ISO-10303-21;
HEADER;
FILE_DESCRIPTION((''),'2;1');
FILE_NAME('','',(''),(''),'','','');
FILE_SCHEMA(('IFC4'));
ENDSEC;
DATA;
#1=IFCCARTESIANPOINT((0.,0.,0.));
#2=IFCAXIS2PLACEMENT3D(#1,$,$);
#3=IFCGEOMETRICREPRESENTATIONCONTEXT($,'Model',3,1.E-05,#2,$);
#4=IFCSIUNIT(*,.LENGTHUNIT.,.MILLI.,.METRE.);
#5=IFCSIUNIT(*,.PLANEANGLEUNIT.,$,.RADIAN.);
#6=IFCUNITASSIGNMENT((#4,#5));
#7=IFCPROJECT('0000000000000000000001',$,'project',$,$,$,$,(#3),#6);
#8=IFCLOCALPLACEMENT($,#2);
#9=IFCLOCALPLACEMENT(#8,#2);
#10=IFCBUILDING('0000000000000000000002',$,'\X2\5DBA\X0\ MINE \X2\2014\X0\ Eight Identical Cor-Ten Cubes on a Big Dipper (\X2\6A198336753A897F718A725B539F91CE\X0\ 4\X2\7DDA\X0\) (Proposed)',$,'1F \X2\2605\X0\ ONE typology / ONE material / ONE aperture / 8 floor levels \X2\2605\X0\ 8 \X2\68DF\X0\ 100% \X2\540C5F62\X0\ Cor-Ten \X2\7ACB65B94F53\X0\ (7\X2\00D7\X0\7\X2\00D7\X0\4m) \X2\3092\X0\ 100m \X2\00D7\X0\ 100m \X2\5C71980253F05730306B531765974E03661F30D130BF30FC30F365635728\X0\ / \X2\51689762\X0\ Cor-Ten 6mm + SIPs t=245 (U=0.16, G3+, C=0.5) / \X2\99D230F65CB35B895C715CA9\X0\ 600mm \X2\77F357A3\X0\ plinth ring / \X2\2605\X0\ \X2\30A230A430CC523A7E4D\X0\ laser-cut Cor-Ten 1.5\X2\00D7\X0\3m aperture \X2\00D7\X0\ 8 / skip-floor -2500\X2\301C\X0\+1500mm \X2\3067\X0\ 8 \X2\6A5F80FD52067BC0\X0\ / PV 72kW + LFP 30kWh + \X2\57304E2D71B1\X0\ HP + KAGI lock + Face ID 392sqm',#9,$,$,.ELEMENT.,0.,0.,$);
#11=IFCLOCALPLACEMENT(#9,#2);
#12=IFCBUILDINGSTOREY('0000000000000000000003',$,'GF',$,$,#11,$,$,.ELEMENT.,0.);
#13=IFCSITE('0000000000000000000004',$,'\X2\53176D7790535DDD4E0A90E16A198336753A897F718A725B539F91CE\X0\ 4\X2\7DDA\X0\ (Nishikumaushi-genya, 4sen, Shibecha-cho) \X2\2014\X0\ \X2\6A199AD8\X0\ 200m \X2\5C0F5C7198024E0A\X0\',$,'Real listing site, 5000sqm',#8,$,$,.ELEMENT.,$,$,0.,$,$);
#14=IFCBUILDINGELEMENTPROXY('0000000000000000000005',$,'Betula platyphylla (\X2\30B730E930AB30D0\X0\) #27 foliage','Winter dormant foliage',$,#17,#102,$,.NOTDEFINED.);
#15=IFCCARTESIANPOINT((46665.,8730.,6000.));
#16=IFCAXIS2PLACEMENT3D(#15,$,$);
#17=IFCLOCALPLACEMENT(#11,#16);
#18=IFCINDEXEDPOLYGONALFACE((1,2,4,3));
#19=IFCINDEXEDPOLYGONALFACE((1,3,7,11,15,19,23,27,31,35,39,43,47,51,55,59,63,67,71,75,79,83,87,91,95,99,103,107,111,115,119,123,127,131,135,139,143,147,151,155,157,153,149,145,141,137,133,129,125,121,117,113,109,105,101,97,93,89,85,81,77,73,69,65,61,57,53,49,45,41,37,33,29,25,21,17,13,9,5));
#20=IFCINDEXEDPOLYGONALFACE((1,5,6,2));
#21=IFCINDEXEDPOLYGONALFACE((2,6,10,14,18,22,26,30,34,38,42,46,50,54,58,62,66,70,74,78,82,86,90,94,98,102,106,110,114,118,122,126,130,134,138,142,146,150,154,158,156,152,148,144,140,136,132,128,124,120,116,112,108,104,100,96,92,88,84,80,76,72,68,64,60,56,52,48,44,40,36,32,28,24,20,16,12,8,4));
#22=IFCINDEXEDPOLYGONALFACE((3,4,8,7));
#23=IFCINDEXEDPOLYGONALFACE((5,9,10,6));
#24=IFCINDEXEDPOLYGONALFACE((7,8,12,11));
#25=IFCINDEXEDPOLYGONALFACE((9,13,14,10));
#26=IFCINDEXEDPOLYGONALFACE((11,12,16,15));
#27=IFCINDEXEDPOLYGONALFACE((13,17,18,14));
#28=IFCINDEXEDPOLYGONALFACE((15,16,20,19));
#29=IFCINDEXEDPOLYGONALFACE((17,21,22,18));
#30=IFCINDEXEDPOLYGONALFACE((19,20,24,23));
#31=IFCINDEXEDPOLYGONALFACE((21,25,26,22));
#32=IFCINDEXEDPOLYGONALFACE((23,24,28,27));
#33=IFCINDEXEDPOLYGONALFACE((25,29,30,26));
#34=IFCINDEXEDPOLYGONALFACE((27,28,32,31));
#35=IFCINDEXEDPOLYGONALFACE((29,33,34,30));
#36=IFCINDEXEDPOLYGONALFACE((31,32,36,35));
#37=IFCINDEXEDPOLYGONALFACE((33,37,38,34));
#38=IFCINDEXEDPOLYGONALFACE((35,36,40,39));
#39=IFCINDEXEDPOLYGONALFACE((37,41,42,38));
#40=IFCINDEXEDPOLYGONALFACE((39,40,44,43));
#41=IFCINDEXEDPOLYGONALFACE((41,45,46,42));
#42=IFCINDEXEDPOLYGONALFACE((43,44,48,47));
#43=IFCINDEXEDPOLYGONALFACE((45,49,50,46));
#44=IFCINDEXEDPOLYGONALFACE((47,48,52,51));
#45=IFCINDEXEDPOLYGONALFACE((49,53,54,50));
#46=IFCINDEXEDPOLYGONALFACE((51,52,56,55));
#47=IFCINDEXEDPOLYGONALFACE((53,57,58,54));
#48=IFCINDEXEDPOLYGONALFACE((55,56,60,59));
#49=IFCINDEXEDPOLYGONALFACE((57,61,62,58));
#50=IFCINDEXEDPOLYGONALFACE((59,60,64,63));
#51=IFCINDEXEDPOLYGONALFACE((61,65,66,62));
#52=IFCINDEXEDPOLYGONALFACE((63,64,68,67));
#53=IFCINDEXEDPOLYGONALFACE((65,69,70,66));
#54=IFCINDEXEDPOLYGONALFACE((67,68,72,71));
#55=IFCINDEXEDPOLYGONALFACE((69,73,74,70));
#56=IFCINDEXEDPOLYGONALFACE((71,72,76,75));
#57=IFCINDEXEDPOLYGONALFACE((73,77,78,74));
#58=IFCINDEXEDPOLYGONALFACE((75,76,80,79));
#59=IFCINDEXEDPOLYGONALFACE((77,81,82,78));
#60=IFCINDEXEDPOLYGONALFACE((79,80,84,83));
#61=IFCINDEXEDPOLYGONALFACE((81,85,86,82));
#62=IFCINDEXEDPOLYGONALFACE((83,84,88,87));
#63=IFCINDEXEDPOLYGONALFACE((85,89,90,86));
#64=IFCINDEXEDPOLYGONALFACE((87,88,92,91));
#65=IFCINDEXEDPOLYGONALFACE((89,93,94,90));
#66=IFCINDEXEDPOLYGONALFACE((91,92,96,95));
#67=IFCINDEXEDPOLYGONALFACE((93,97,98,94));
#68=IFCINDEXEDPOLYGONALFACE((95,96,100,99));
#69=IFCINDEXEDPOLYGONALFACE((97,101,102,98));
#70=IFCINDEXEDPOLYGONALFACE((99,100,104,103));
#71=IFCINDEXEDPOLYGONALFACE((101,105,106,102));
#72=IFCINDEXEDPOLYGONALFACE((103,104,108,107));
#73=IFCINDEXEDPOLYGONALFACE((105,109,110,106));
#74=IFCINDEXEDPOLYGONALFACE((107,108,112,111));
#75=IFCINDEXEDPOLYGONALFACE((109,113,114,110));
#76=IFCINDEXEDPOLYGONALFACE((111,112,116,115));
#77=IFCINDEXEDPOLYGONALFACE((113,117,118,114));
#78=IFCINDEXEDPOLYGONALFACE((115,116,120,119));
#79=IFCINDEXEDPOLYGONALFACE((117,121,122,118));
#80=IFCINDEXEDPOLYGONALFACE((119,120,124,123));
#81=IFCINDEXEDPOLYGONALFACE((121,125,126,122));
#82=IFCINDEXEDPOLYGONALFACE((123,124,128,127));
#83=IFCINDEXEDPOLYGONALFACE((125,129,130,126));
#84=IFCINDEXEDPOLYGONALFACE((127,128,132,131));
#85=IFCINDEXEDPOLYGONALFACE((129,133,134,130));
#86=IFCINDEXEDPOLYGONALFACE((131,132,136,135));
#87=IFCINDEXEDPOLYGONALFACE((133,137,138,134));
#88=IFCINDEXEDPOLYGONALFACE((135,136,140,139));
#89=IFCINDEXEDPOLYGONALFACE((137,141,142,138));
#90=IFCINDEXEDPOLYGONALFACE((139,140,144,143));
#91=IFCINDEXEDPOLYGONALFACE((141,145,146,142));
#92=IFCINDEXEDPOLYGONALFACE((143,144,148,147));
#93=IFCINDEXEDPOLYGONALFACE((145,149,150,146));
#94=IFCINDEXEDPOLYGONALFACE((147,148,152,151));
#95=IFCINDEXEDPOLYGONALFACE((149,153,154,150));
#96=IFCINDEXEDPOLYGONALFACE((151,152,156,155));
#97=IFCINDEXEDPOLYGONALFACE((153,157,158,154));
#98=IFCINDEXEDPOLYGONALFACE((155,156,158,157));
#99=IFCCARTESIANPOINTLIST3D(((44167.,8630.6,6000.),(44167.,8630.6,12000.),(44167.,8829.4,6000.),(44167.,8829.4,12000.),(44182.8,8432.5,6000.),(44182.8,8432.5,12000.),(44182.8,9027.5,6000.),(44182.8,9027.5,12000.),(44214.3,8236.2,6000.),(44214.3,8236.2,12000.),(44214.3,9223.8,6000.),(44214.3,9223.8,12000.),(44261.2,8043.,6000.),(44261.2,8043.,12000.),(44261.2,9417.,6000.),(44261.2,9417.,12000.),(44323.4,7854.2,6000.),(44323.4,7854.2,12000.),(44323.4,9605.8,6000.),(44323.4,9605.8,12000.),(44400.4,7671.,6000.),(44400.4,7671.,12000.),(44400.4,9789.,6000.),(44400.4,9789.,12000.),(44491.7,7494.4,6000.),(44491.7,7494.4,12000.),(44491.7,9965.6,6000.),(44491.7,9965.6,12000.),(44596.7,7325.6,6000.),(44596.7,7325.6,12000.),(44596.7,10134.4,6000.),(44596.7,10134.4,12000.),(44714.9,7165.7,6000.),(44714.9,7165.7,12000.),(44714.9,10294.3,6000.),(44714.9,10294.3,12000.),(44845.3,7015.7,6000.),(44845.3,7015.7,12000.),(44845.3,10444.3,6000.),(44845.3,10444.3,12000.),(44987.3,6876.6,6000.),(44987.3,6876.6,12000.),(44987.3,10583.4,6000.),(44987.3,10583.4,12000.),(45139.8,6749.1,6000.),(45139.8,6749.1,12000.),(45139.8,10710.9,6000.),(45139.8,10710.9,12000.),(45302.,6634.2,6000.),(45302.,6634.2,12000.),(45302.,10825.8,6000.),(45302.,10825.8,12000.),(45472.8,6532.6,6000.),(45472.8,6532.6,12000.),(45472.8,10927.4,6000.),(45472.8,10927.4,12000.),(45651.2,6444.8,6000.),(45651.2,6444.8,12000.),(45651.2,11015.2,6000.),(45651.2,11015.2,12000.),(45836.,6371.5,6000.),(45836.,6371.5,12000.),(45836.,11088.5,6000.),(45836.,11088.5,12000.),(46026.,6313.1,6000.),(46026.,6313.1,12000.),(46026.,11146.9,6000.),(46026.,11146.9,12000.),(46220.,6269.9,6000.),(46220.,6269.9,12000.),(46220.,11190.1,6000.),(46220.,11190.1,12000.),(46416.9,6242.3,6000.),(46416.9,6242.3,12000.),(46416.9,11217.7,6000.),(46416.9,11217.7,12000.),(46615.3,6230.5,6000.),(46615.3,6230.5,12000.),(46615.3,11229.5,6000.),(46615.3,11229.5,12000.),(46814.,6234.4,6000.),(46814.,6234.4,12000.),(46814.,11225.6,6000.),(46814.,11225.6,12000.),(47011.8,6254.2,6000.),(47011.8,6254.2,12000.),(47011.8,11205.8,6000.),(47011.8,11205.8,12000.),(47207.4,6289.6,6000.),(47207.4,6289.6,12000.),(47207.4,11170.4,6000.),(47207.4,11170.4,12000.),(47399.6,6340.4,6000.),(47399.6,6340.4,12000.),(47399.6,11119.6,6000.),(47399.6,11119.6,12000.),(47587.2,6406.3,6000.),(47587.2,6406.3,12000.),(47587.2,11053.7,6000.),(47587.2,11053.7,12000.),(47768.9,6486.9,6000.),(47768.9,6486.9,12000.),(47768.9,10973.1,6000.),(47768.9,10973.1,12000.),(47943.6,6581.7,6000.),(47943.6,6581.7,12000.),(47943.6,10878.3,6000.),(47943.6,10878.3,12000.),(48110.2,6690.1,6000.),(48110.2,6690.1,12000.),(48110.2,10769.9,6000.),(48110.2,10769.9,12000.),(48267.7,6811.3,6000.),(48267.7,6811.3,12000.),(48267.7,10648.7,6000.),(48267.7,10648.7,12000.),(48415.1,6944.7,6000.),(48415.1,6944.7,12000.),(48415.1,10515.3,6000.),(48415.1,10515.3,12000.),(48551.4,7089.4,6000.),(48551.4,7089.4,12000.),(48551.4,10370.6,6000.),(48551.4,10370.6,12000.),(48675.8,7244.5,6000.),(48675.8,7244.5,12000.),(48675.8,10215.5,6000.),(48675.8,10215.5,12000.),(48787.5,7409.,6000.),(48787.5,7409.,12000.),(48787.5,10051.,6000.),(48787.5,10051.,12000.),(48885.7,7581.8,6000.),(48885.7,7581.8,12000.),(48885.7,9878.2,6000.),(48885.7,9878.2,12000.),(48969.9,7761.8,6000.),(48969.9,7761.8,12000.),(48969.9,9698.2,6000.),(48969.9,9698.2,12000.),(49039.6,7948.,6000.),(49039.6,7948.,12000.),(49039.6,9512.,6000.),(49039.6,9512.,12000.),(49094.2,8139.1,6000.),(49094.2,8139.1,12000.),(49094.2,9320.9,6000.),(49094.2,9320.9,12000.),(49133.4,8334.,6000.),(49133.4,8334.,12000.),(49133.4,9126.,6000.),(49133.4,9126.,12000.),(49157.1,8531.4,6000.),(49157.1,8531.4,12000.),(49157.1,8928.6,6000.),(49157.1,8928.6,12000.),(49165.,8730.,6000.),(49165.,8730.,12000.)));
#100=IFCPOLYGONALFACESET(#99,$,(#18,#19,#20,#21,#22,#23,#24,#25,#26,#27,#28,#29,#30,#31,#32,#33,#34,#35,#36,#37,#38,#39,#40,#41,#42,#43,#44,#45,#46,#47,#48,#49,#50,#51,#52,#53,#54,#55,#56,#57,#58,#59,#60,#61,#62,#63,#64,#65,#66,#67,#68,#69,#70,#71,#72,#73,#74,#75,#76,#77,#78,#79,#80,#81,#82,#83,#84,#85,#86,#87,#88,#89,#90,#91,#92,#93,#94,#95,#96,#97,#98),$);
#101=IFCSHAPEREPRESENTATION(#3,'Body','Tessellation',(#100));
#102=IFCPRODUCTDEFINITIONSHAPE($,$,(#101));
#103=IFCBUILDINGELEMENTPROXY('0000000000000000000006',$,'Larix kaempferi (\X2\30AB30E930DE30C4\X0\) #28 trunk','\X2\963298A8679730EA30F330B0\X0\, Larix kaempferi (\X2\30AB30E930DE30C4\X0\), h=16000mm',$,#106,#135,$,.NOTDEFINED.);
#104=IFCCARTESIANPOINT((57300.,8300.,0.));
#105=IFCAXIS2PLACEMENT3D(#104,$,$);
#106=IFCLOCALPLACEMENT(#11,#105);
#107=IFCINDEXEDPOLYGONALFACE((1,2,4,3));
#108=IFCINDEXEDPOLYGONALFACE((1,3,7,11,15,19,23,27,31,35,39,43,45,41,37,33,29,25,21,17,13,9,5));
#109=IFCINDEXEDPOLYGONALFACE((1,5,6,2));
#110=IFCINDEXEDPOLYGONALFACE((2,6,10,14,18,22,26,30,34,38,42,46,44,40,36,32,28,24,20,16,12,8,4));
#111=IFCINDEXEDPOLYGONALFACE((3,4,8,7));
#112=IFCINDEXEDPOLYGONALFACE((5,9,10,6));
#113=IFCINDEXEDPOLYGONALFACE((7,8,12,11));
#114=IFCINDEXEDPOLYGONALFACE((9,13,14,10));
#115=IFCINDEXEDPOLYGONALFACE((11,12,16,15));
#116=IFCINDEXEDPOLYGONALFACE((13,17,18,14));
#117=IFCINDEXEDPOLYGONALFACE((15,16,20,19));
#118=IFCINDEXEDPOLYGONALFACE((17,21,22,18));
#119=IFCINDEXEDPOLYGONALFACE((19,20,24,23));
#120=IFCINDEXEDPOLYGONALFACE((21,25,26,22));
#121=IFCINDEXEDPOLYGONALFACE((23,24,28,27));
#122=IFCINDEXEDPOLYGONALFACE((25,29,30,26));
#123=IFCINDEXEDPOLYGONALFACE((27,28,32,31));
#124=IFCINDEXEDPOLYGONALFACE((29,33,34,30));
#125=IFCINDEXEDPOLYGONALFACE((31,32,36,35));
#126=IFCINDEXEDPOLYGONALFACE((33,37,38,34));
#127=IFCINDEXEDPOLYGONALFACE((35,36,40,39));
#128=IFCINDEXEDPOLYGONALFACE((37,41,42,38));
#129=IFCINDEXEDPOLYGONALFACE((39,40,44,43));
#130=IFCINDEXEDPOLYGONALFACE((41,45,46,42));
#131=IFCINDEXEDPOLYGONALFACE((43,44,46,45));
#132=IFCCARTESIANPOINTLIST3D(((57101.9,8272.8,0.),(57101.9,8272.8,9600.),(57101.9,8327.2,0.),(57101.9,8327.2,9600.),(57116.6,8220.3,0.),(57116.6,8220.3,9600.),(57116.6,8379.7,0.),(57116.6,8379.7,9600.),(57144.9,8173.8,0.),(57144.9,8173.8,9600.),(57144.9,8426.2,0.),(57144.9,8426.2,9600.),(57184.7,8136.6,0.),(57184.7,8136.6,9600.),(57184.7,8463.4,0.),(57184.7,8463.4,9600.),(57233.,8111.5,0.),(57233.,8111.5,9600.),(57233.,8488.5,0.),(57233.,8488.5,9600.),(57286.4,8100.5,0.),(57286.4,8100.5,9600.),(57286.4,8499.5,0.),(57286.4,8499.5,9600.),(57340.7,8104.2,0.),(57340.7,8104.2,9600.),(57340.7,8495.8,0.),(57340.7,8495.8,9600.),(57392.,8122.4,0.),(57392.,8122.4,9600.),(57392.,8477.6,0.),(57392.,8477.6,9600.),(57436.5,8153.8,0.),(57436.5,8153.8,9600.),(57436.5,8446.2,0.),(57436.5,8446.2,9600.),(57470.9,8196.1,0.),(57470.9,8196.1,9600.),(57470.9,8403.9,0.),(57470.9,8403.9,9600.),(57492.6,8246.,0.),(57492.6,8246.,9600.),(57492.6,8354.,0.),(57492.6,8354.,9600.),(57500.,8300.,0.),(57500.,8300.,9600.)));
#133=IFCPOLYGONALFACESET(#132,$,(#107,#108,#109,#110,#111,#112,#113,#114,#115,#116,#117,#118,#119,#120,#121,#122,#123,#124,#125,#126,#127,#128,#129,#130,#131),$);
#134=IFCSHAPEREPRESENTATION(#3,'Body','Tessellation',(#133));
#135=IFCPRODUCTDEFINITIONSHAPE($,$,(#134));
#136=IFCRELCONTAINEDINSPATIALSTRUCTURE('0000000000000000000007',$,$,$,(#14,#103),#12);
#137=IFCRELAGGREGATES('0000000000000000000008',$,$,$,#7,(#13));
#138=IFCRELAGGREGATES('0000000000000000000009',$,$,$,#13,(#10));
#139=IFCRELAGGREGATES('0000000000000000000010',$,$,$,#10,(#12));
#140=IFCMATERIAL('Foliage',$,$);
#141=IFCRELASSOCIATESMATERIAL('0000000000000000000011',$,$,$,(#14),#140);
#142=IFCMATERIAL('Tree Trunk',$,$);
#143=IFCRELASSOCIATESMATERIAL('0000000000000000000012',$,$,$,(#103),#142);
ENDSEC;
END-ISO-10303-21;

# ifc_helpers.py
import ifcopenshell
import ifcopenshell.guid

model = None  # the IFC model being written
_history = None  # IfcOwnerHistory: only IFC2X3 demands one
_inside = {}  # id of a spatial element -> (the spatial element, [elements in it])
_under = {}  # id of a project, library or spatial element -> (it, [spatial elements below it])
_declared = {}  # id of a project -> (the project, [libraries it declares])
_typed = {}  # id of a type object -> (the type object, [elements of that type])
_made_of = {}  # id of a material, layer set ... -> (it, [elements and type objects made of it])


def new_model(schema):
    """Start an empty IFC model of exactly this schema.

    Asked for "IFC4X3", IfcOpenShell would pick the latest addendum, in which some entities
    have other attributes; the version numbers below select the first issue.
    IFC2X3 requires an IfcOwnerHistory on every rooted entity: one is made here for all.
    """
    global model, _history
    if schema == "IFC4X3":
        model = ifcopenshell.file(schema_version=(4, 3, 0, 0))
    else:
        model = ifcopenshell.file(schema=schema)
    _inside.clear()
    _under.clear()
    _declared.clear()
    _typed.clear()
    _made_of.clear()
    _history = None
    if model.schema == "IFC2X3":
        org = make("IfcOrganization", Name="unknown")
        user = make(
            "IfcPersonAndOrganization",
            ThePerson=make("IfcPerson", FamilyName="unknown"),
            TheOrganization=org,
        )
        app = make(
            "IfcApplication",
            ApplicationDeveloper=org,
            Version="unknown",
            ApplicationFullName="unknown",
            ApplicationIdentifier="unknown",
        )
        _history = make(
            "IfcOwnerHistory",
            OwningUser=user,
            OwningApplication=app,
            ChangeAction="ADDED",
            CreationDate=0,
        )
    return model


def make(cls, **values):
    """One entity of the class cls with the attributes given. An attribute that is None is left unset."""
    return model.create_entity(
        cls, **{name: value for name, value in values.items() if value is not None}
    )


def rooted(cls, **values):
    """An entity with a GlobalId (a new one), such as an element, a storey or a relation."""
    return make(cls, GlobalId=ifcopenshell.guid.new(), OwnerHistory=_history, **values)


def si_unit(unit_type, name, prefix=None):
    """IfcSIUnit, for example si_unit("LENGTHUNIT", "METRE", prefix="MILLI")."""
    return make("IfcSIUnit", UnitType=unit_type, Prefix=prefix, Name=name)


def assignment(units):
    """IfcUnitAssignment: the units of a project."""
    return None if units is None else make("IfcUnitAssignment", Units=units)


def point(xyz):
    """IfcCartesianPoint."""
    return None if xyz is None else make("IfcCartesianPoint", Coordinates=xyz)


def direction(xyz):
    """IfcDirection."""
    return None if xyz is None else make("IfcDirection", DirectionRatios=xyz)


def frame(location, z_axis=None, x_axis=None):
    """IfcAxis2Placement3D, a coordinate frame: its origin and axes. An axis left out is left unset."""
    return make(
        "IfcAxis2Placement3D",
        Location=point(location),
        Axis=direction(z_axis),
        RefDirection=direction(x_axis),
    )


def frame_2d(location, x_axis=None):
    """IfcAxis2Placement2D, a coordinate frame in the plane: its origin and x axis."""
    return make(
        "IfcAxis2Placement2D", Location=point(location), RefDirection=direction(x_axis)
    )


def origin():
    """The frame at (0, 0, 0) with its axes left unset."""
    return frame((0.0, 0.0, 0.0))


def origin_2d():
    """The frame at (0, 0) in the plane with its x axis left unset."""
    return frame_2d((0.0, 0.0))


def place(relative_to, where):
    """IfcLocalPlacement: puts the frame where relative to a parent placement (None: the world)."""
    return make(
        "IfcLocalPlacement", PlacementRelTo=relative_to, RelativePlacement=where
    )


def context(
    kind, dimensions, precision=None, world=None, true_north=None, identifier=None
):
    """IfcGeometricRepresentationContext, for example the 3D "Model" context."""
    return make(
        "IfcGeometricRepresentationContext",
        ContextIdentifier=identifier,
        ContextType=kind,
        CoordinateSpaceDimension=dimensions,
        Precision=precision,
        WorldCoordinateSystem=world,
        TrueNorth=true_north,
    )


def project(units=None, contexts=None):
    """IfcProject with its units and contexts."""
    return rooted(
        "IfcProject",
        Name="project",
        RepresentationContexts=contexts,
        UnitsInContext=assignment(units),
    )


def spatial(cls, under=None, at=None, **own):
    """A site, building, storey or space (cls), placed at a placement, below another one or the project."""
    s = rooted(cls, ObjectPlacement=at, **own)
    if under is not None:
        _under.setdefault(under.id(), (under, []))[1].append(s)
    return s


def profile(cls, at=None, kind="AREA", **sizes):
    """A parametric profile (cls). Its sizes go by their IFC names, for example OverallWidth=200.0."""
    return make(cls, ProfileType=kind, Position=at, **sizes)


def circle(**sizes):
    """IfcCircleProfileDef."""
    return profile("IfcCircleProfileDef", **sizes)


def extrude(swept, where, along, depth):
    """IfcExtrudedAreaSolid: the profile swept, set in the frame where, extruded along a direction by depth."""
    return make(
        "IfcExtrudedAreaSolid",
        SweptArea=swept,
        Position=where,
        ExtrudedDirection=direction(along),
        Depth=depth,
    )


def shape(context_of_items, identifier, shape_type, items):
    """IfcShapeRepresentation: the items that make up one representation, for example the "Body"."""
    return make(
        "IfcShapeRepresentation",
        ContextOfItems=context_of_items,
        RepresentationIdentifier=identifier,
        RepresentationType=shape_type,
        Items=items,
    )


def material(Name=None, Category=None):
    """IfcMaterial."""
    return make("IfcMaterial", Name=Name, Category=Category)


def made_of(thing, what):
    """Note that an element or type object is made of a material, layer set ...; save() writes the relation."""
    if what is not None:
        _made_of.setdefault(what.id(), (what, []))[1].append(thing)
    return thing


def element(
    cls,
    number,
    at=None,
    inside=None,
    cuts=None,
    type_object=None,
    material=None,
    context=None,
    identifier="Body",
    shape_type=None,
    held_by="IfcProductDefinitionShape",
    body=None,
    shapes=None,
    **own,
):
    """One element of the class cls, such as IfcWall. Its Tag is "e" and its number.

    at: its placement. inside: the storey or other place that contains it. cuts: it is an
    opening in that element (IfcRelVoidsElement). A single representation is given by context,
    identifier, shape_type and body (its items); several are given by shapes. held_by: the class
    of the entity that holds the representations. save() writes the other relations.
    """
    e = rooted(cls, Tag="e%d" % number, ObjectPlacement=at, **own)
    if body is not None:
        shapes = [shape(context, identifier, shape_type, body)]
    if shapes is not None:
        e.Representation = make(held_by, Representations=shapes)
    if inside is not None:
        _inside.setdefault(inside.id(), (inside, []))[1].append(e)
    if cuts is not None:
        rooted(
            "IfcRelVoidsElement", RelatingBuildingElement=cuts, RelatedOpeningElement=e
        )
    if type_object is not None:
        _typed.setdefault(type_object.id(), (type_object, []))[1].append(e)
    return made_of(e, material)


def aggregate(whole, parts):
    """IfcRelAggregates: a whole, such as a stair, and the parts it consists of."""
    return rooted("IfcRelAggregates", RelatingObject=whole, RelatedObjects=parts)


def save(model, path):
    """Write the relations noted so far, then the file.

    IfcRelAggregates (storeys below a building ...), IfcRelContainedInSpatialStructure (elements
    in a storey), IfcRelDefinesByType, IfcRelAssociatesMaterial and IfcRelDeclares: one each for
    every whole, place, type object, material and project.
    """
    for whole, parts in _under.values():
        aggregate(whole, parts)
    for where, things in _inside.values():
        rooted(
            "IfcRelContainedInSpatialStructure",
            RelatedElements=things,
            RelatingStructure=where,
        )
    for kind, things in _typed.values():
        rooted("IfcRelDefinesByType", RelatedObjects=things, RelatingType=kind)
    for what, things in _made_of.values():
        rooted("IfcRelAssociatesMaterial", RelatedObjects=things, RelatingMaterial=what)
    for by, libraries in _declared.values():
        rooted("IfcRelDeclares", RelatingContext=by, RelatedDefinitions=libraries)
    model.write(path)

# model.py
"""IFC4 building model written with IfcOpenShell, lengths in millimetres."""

from ifc_helpers import new_model, si_unit, frame, origin, origin_2d, place, context, project, spatial, circle, extrude, material, element, save


model = new_model("IFC4")

# Units and contexts
model_context = context("Model", 3, precision=1e-05, world=origin())
ifc_project = project(units=[si_unit("LENGTHUNIT", "METRE", prefix="MILLI"), si_unit("PLANEANGLEUNIT", "RADIAN")], contexts=[model_context])

# Site, building, storey
site_placement = place(None, origin())
site = spatial("IfcSite", under=ifc_project, at=site_placement, Name="北海道川上郡標茶町西熊牛原野 4線 (Nishikumaushi-genya, 4sen, Shibecha-cho) — 標高 200m 小山頂上", ObjectType="Real listing site, 5000sqm", CompositionType="ELEMENT", RefElevation=0.0)
building_placement = place(site_placement, origin())
building = spatial("IfcBuilding", under=site, at=building_placement, Name="嶺 MINE — Eight Identical Cor-Ten Cubes on a Big Dipper (標茶町西熊牛原野 4線) (Proposed)", ObjectType="1F ★ ONE typology / ONE material / ONE aperture / 8 floor levels ★ 8 棟 100% 同形 Cor-Ten 立方体 (7×7×4m) を 100m × 100m 山頂台地に北斗七星パターン散在 / 全面 Cor-Ten 6mm + SIPs t=245 (U=0.16, G3+, C=0.5) / 駒ヶ岳安山岩 600mm 石垣 plinth ring / ★ アイヌ刺繍 laser-cut Cor-Ten 1.5×3m aperture × 8 / skip-floor -2500〜+1500mm で 8 機能分節 / PV 72kW + LFP 30kWh + 地中熱 HP + KAGI lock + Face ID 392sqm", CompositionType="ELEMENT", ElevationOfRefHeight=0.0, ElevationOfTerrain=0.0)
storey_placement = place(building_placement, origin())
storey = spatial("IfcBuildingStorey", under=building, at=storey_placement, Name="GF", CompositionType="ELEMENT", Elevation=0.0)

# Building element proxies
ifc_material_1 = material(Name="Tree Trunk")
ifc_material_2 = material(Name="Foliage")
proxy_1_placement = place(storey_placement, frame((46665.0, 8730.0, 6000.0)))
element("IfcBuildingElementProxy", 1, at=proxy_1_placement, inside=storey, material=ifc_material_2, Name="Betula platyphylla (シラカバ) #27 foliage", Description="Winter dormant foliage", PredefinedType="NOTDEFINED", context=model_context, shape_type="SweptSolid", body=[
    extrude(circle(Radius=2500.0, at=origin_2d()), frame((46665.0, 8730.0, 6000.0)), (0.0, 0.0, 1.0), 6000.0),
])
proxy_2_placement = place(storey_placement, frame((57300.0, 8300.0, 0.0)))
element("IfcBuildingElementProxy", 2, at=proxy_2_placement, inside=storey, material=ifc_material_1, Name="Larix kaempferi (カラマツ) #28 trunk", Description="防風林リング, Larix kaempferi (カラマツ), h=16000mm", PredefinedType="NOTDEFINED", context=model_context, shape_type="SweptSolid", body=[
    extrude(circle(Radius=200.0, at=origin_2d()), frame((57300.0, 8300.0, 0.0)), (0.0, 0.0, 1.0), 9600.0),
])

save(model, "model.ifc")
